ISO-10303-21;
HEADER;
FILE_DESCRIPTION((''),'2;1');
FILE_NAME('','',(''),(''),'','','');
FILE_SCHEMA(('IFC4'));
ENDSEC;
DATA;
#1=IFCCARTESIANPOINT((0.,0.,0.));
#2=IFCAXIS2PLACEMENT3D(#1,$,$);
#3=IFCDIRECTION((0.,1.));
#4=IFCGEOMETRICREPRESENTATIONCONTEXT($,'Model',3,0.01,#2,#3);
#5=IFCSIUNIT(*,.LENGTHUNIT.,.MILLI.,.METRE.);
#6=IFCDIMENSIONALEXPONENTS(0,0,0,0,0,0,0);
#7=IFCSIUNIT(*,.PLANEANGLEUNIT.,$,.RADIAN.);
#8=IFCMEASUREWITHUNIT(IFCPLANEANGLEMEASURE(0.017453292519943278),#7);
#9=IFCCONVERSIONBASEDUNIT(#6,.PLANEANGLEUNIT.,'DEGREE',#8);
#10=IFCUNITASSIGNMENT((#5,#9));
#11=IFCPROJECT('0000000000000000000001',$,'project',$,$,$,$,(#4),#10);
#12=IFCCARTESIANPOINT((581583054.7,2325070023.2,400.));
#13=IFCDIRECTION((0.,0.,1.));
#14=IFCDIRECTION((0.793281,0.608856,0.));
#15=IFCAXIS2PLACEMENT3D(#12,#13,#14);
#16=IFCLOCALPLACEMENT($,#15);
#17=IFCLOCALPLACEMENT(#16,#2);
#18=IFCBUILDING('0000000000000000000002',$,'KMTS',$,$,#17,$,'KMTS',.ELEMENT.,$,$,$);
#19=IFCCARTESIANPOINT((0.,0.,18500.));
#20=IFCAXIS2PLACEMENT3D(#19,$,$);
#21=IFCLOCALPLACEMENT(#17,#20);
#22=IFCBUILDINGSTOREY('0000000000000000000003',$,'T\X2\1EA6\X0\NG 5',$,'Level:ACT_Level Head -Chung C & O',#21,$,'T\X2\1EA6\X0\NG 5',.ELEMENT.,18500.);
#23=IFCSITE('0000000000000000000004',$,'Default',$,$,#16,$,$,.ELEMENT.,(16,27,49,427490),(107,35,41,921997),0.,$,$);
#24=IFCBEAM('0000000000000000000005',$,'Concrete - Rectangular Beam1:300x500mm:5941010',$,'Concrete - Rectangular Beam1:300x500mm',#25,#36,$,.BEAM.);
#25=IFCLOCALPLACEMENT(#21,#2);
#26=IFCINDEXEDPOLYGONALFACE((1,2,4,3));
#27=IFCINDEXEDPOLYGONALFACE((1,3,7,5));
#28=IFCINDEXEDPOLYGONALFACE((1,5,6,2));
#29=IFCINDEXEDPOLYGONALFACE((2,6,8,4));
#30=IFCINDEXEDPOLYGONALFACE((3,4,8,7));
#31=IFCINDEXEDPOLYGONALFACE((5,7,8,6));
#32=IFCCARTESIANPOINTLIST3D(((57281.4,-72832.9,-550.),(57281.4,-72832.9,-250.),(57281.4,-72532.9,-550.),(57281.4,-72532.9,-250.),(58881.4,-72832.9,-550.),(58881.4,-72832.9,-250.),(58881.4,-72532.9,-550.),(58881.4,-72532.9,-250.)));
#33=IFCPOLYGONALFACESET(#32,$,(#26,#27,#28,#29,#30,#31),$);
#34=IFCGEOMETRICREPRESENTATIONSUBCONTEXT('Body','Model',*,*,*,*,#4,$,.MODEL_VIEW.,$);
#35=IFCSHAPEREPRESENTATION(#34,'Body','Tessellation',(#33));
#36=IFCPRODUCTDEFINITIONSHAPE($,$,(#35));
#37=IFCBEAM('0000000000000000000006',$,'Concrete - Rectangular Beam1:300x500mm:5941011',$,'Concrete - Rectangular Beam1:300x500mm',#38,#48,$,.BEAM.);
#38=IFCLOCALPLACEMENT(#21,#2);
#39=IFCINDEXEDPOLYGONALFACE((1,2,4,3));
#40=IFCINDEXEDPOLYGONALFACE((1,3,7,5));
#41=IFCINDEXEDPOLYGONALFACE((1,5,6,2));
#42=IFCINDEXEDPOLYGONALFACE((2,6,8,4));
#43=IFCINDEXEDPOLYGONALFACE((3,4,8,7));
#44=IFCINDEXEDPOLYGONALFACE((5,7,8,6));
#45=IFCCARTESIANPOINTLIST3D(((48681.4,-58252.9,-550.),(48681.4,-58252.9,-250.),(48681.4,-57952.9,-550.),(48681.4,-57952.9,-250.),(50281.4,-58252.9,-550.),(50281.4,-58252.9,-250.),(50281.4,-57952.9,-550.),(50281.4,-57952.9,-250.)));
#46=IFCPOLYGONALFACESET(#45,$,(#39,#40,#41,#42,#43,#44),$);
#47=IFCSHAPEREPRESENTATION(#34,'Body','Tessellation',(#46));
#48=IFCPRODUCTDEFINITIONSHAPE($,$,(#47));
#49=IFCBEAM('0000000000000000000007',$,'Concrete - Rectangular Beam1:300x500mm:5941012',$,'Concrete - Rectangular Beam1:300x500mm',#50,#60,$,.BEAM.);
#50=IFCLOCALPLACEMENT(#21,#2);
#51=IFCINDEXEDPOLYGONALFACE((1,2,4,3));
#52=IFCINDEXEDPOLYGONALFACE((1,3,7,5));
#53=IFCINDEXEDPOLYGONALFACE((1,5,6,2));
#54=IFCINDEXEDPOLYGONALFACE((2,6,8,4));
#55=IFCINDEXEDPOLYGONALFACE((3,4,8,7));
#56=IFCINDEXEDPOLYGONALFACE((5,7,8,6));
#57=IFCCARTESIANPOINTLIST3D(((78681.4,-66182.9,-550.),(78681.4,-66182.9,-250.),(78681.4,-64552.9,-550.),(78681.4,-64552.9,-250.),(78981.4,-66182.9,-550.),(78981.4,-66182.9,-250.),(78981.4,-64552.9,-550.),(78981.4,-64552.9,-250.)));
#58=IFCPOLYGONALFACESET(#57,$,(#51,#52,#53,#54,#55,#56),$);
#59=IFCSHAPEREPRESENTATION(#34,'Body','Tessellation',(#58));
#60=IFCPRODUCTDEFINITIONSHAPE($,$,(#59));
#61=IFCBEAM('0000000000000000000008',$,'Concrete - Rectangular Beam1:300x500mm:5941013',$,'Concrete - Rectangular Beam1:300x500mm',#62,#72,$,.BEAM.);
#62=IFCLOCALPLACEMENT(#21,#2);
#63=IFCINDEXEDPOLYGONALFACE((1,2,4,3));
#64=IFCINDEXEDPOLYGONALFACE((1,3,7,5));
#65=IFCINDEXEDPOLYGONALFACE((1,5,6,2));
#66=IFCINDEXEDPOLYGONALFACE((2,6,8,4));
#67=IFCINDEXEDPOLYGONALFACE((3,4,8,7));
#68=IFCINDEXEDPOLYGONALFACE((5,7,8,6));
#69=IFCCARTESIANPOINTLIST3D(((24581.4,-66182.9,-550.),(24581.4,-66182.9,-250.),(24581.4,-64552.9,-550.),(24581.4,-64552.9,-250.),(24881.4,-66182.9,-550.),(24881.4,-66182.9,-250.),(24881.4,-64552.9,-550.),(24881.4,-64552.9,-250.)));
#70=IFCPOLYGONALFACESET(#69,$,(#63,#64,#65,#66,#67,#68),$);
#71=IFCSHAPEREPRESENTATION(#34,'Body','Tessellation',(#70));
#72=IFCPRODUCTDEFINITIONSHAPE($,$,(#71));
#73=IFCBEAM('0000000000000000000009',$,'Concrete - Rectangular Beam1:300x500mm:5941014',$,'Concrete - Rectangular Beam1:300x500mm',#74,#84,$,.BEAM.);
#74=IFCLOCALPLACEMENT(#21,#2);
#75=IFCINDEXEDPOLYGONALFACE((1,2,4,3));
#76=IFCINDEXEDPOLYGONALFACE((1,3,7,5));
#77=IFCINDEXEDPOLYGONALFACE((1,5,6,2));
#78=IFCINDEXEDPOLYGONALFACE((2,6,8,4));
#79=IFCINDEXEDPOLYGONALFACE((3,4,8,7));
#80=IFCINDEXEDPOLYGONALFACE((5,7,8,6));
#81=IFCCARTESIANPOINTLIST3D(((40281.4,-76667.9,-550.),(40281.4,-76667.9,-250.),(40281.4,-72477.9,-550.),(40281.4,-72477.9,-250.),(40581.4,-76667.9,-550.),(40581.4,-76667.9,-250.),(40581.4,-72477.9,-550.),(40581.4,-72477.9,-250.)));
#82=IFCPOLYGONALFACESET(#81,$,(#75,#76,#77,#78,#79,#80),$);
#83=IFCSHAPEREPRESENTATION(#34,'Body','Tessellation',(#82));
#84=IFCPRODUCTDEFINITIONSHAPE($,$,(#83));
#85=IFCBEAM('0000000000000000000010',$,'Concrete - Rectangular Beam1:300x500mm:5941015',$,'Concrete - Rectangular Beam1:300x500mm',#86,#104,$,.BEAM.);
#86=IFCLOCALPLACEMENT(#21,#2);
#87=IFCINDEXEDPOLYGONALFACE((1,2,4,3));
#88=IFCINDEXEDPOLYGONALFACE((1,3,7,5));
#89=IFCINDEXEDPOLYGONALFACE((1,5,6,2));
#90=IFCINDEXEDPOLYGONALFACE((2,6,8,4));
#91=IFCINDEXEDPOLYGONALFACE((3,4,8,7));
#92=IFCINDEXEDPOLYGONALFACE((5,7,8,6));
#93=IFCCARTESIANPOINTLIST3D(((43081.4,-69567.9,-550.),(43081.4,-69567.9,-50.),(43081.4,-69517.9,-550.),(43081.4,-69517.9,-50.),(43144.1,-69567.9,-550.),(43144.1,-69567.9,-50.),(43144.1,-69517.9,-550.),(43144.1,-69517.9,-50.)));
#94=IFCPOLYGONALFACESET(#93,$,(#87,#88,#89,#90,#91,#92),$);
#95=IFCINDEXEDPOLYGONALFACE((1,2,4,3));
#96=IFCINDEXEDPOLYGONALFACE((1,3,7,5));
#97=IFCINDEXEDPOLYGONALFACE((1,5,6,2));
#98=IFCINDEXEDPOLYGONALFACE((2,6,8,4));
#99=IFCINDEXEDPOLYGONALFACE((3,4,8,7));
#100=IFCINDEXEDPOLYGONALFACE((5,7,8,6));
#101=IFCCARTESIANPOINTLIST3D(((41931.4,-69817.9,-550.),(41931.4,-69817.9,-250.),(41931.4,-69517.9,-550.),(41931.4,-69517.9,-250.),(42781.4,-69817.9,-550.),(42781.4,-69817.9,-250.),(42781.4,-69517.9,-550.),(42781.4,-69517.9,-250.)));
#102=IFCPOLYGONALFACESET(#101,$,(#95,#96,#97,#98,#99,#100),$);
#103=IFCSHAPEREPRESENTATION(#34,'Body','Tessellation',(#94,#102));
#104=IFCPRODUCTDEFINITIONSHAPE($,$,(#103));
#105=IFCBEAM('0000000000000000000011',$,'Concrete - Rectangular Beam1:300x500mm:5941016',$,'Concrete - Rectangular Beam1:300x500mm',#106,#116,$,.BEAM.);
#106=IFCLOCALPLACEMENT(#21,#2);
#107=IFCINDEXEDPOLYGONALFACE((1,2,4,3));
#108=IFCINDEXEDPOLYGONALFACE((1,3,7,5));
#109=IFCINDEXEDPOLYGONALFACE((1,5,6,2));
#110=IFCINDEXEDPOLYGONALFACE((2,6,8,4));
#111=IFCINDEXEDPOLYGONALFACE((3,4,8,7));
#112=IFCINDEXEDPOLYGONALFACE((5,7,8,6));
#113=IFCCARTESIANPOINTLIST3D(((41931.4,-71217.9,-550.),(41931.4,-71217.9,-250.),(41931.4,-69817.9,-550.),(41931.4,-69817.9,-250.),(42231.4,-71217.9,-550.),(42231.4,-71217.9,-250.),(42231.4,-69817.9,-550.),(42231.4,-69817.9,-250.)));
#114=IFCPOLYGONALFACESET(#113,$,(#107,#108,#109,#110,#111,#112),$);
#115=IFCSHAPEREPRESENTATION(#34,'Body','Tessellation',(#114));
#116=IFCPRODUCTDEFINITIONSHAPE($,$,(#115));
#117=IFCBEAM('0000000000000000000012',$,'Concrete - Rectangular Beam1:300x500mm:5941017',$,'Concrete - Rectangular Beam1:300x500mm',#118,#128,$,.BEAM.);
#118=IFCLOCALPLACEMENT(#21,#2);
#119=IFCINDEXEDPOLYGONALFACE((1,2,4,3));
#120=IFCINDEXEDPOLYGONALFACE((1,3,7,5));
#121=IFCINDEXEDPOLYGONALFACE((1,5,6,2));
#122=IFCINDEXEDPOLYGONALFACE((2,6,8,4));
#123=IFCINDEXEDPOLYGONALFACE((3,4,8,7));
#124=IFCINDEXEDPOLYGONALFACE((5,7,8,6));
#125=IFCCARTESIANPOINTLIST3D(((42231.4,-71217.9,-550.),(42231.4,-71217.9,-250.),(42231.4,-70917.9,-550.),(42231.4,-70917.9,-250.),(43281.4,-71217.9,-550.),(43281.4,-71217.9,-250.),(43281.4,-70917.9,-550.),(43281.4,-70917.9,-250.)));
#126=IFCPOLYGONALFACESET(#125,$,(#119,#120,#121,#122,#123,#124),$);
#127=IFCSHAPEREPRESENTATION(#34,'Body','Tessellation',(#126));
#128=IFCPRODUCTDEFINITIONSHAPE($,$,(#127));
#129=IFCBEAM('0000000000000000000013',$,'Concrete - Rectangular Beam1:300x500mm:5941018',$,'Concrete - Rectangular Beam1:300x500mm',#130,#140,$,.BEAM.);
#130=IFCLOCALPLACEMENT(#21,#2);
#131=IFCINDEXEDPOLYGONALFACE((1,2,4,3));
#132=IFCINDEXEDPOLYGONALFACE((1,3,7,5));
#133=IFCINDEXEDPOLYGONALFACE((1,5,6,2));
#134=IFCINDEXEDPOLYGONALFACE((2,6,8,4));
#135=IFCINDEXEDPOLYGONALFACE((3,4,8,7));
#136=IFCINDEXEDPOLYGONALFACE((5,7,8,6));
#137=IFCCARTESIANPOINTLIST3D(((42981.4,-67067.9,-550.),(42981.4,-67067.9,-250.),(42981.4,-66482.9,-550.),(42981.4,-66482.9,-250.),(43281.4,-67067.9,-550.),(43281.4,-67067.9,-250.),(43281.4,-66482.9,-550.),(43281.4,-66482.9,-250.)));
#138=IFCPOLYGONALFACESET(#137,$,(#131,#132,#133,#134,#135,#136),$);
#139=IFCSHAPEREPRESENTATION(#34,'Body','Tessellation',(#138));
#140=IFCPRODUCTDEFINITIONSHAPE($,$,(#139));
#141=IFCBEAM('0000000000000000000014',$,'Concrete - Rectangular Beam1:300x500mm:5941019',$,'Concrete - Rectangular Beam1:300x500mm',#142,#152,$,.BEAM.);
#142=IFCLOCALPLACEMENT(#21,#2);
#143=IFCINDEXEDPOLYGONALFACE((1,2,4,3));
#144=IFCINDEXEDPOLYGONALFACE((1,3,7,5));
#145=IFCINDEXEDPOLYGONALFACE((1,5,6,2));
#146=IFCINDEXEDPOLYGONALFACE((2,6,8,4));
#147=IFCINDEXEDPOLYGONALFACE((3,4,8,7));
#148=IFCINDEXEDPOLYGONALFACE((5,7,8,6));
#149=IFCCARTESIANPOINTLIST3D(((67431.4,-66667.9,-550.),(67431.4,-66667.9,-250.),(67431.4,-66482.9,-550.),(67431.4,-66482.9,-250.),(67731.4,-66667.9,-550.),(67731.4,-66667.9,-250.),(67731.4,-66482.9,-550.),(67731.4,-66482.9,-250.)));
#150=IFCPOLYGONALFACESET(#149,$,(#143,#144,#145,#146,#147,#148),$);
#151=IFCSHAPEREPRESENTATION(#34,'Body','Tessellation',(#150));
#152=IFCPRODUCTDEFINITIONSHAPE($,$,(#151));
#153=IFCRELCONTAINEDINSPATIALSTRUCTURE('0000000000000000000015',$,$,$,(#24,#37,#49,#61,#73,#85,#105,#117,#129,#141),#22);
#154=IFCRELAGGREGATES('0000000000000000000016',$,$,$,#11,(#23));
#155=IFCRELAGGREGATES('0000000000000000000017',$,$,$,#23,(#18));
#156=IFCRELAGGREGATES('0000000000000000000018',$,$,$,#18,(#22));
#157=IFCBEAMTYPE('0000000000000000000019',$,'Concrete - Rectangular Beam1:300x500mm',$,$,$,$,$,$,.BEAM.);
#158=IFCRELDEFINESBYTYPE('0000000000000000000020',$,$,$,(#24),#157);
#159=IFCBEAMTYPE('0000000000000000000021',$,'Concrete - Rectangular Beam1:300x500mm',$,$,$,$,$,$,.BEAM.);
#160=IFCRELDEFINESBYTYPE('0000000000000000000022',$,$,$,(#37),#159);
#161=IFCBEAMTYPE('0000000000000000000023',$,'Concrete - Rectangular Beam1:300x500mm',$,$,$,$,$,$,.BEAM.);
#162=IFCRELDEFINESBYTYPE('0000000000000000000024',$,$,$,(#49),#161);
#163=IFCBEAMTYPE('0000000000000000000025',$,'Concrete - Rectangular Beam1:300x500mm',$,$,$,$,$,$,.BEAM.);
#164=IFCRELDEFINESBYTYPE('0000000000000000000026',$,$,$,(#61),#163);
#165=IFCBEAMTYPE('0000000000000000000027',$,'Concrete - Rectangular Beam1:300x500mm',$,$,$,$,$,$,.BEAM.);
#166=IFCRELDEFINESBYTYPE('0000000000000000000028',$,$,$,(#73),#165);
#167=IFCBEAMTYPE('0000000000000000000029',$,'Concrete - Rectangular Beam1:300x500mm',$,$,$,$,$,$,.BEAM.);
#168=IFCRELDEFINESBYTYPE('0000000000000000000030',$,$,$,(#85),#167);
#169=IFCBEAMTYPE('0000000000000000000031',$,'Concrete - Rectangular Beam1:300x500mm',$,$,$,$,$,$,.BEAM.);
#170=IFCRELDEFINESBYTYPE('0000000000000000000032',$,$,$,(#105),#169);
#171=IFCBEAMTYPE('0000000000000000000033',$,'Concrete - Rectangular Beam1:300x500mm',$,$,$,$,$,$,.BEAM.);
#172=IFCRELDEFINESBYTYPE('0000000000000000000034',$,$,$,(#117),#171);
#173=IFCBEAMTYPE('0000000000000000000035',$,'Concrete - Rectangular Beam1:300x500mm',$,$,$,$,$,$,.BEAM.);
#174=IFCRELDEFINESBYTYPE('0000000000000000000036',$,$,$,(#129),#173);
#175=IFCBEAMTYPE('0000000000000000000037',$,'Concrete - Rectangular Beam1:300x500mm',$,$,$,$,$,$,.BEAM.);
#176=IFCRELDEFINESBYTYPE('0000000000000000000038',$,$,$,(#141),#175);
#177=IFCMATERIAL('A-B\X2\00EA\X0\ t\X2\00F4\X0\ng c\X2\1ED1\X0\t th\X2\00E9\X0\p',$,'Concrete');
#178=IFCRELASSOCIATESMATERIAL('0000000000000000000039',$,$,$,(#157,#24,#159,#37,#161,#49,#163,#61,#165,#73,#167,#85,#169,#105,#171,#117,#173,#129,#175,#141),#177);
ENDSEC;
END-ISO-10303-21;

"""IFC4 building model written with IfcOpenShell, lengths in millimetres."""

from ifc_helpers import new_model, entity, si_unit, converted_unit, direction, frame, origin, place, context, subcontext, project, spatial, indexed_curve, outline, extrude, source, transform, mapped, material, type_object, type_shapes, element, save


model = new_model("IFC4")

# Units and contexts
model_context = context("Model", 3, precision=0.01, world=origin(), true_north=direction((0.0, 1.0)))
body_context = subcontext(model_context, "Body", "Model", "MODEL_VIEW")
ifc_project = project(units=[si_unit("LENGTHUNIT", "METRE", prefix="MILLI"), converted_unit("PLANEANGLEUNIT", "DEGREE", entity("IfcPlaneAngleMeasure", 0.017453292519943278), si_unit("PLANEANGLEUNIT", "RADIAN"), dimensions=[0, 0, 0, 0, 0, 0, 0])], contexts=[model_context])

# Site, building, storey
site_placement = place(None, frame((581583054.7, 2325070023.2, 400.0), z_axis=(0.0, 0.0, 1.0), x_axis=(0.793281, 0.608856, 0.0)))
site = spatial("IfcSite", under=ifc_project, at=site_placement, Name="Default", CompositionType="ELEMENT", RefLatitude=(16, 27, 49, 427490), RefLongitude=(107, 35, 41, 921997), RefElevation=0.0)
building_placement = place(site_placement, origin())
building = spatial("IfcBuilding", under=site, at=building_placement, Name="KMTS", LongName="KMTS", CompositionType="ELEMENT")
storey_placement = place(building_placement, frame((0.0, 0.0, 18500.0)))
storey = spatial("IfcBuildingStorey", under=building, at=storey_placement, Name="TẦNG 5", ObjectType="Level:ACT_Level Head -Chung C & O", LongName="TẦNG 5", CompositionType="ELEMENT", Elevation=18500.0)

# Beams
ifc_material_1 = material(Name="A-Bê tông cốt thép", Category="Concrete")
beam_type_1 = type_object("IfcBeamType", Name="Concrete - Rectangular Beam1:300x500mm", PredefinedType="BEAM", material=ifc_material_1)
shared_shape_1 = source(origin(), body_context, "Body", "SweptSolid", [
    extrude(outline(indexed_curve([(-150.0, -150.0), (150.0, -150.0), (150.0, 150.0), (-150.0, 150.0), (-150.0, -150.0)], self_intersect=False)), frame((57281.4, -72682.9, 18100.0), z_axis=(1.0, 0.0, 0.0), x_axis=(0.0, 0.0, -1.0)), (0.0, 0.0, 1.0), 1600.0),
])
type_shapes(beam_type_1, [shared_shape_1])
beam_1_placement = place(storey_placement, frame((0.0, 0.0, -18500.0)))
element("IfcBeam", 1, at=beam_1_placement, inside=storey, type_object=beam_type_1, material=ifc_material_1, Name="Concrete - Rectangular Beam1:300x500mm:5941010", ObjectType="Concrete - Rectangular Beam1:300x500mm", PredefinedType="BEAM", context=body_context, shape_type="MappedRepresentation", body=[
    mapped(shared_shape_1, transform((0.0, 0.0, 0.0), scale=1.0)),
])
beam_type_2 = type_object("IfcBeamType", Name="Concrete - Rectangular Beam1:300x500mm", PredefinedType="BEAM", material=ifc_material_1)
shared_shape_2 = source(origin(), body_context, "Body", "SweptSolid", [
    extrude(outline(indexed_curve([(-150.0, -150.0), (150.0, -150.0), (150.0, 150.0), (-150.0, 150.0), (-150.0, -150.0)], self_intersect=False)), frame((50281.4, -58102.9, 18100.0), z_axis=(-1.0, 0.0, 0.0), x_axis=(0.0, 0.0, -1.0)), (0.0, 0.0, 1.0), 1600.0),
])
type_shapes(beam_type_2, [shared_shape_2])
beam_2_placement = place(storey_placement, frame((0.0, 0.0, -18500.0)))
element("IfcBeam", 2, at=beam_2_placement, inside=storey, type_object=beam_type_2, material=ifc_material_1, Name="Concrete - Rectangular Beam1:300x500mm:5941011", ObjectType="Concrete - Rectangular Beam1:300x500mm", PredefinedType="BEAM", context=body_context, shape_type="MappedRepresentation", body=[
    mapped(shared_shape_2, transform((0.0, 0.0, 0.0), scale=1.0)),
])
beam_type_3 = type_object("IfcBeamType", Name="Concrete - Rectangular Beam1:300x500mm", PredefinedType="BEAM", material=ifc_material_1)
shared_shape_3 = source(origin(), body_context, "Body", "SweptSolid", [
    extrude(outline(indexed_curve([(-150.0, -150.0), (150.0, -150.0), (150.0, 150.0), (-150.0, 150.0), (-150.0, -150.0)], self_intersect=False)), frame((78831.4, -66182.9, 18100.0), z_axis=(0.0, 1.0, 0.0), x_axis=(-1.0, 0.0, 0.0)), (0.0, 0.0, 1.0), 1630.0),
])
type_shapes(beam_type_3, [shared_shape_3])
beam_3_placement = place(storey_placement, frame((0.0, 0.0, -18500.0)))
element("IfcBeam", 3, at=beam_3_placement, inside=storey, type_object=beam_type_3, material=ifc_material_1, Name="Concrete - Rectangular Beam1:300x500mm:5941012", ObjectType="Concrete - Rectangular Beam1:300x500mm", PredefinedType="BEAM", context=body_context, shape_type="MappedRepresentation", body=[
    mapped(shared_shape_3, transform((0.0, 0.0, 0.0), scale=1.0)),
])
beam_type_4 = type_object("IfcBeamType", Name="Concrete - Rectangular Beam1:300x500mm", PredefinedType="BEAM", material=ifc_material_1)
shared_shape_4 = source(origin(), body_context, "Body", "SweptSolid", [
    extrude(outline(indexed_curve([(-150.0, -150.0), (150.0, -150.0), (150.0, 150.0), (-150.0, 150.0), (-150.0, -150.0)], self_intersect=False)), frame((24731.4, -64552.9, 18100.0), z_axis=(0.0, -1.0, 0.0), x_axis=(-1.0, 0.0, 0.0)), (0.0, 0.0, 1.0), 1630.0),
])
type_shapes(beam_type_4, [shared_shape_4])
beam_4_placement = place(storey_placement, frame((0.0, 0.0, -18500.0)))
element("IfcBeam", 4, at=beam_4_placement, inside=storey, type_object=beam_type_4, material=ifc_material_1, Name="Concrete - Rectangular Beam1:300x500mm:5941013", ObjectType="Concrete - Rectangular Beam1:300x500mm", PredefinedType="BEAM", context=body_context, shape_type="MappedRepresentation", body=[
    mapped(shared_shape_4, transform((0.0, 0.0, 0.0), scale=1.0)),
])
beam_type_5 = type_object("IfcBeamType", Name="Concrete - Rectangular Beam1:300x500mm", PredefinedType="BEAM", material=ifc_material_1)
shared_shape_5 = source(origin(), body_context, "Body", "SweptSolid", [
    extrude(outline(indexed_curve([(-150.0, -150.0), (150.0, -150.0), (150.0, 150.0), (-150.0, 150.0), (-150.0, -150.0)], self_intersect=False)), frame((40431.4, -72477.9, 18100.0), z_axis=(0.0, -1.0, 0.0), x_axis=(-1.0, 0.0, 0.0)), (0.0, 0.0, 1.0), 4190.0),
])
type_shapes(beam_type_5, [shared_shape_5])
beam_5_placement = place(storey_placement, frame((0.0, 0.0, -18500.0)))
element("IfcBeam", 5, at=beam_5_placement, inside=storey, type_object=beam_type_5, material=ifc_material_1, Name="Concrete - Rectangular Beam1:300x500mm:5941014", ObjectType="Concrete - Rectangular Beam1:300x500mm", PredefinedType="BEAM", context=body_context, shape_type="MappedRepresentation", body=[
    mapped(shared_shape_5, transform((0.0, 0.0, 0.0), scale=1.0)),
])
beam_type_6 = type_object("IfcBeamType", Name="Concrete - Rectangular Beam1:300x500mm", PredefinedType="BEAM", material=ifc_material_1)
shared_shape_6 = source(origin(), body_context, "Body", "SweptSolid", [
    extrude(outline(indexed_curve([(-250.0, -25.0), (250.0, -25.0), (250.0, 25.0), (-250.0, 25.0), (-250.0, -25.0)], self_intersect=False)), frame((43144.1, -69542.9, 18200.0), z_axis=(-1.0, 0.0, 0.0), x_axis=(0.0, 0.0, -1.0)), (0.0, 0.0, 1.0), 62.7),
    extrude(outline(indexed_curve([(-150.0, -150.0), (150.0, -150.0), (150.0, 150.0), (-150.0, 150.0), (-150.0, -150.0)], self_intersect=False)), frame((42781.4, -69667.9, 18100.0), z_axis=(-1.0, 0.0, 0.0), x_axis=(0.0, 0.0, -1.0)), (0.0, 0.0, 1.0), 850.0),
])
type_shapes(beam_type_6, [shared_shape_6])
beam_6_placement = place(storey_placement, frame((0.0, 0.0, -18500.0)))
element("IfcBeam", 6, at=beam_6_placement, inside=storey, type_object=beam_type_6, material=ifc_material_1, Name="Concrete - Rectangular Beam1:300x500mm:5941015", ObjectType="Concrete - Rectangular Beam1:300x500mm", PredefinedType="BEAM", context=body_context, shape_type="MappedRepresentation", body=[
    mapped(shared_shape_6, transform((0.0, 0.0, 0.0), scale=1.0)),
])
beam_type_7 = type_object("IfcBeamType", Name="Concrete - Rectangular Beam1:300x500mm", PredefinedType="BEAM", material=ifc_material_1)
shared_shape_7 = source(origin(), body_context, "Body", "SweptSolid", [
    extrude(outline(indexed_curve([(-150.0, -150.0), (150.0, -150.0), (150.0, 150.0), (-150.0, 150.0), (-150.0, -150.0)], self_intersect=False)), frame((42081.4, -69817.9, 18100.0), z_axis=(0.0, -1.0, 0.0), x_axis=(-1.0, 0.0, 0.0)), (0.0, 0.0, 1.0), 1400.0),
])
type_shapes(beam_type_7, [shared_shape_7])
beam_7_placement = place(storey_placement, frame((0.0, 0.0, -18500.0)))
element("IfcBeam", 7, at=beam_7_placement, inside=storey, type_object=beam_type_7, material=ifc_material_1, Name="Concrete - Rectangular Beam1:300x500mm:5941016", ObjectType="Concrete - Rectangular Beam1:300x500mm", PredefinedType="BEAM", context=body_context, shape_type="MappedRepresentation", body=[
    mapped(shared_shape_7, transform((0.0, 0.0, 0.0), scale=1.0)),
])
beam_type_8 = type_object("IfcBeamType", Name="Concrete - Rectangular Beam1:300x500mm", PredefinedType="BEAM", material=ifc_material_1)
shared_shape_8 = source(origin(), body_context, "Body", "SweptSolid", [
    extrude(outline(indexed_curve([(-150.0, -150.0), (150.0, -150.0), (150.0, 150.0), (-150.0, 150.0), (-150.0, -150.0)], self_intersect=False)), frame((42231.4, -71067.9, 18100.0), z_axis=(1.0, 0.0, 0.0), x_axis=(0.0, 0.0, -1.0)), (0.0, 0.0, 1.0), 1050.0),
])
type_shapes(beam_type_8, [shared_shape_8])
beam_8_placement = place(storey_placement, frame((0.0, 0.0, -18500.0)))
element("IfcBeam", 8, at=beam_8_placement, inside=storey, type_object=beam_type_8, material=ifc_material_1, Name="Concrete - Rectangular Beam1:300x500mm:5941017", ObjectType="Concrete - Rectangular Beam1:300x500mm", PredefinedType="BEAM", context=body_context, shape_type="MappedRepresentation", body=[
    mapped(shared_shape_8, transform((0.0, 0.0, 0.0), scale=1.0)),
])
beam_type_9 = type_object("IfcBeamType", Name="Concrete - Rectangular Beam1:300x500mm", PredefinedType="BEAM", material=ifc_material_1)
shared_shape_9 = source(origin(), body_context, "Body", "SweptSolid", [
    extrude(outline(indexed_curve([(-150.0, -150.0), (150.0, -150.0), (150.0, 150.0), (-150.0, 150.0), (-150.0, -150.0)], self_intersect=False)), frame((43131.4, -66482.9, 18100.0), z_axis=(0.0, -1.0, 0.0), x_axis=(-1.0, 0.0, 0.0)), (0.0, 0.0, 1.0), 585.0),
])
type_shapes(beam_type_9, [shared_shape_9])
beam_9_placement = place(storey_placement, frame((0.0, 0.0, -18500.0)))
element("IfcBeam", 9, at=beam_9_placement, inside=storey, type_object=beam_type_9, material=ifc_material_1, Name="Concrete - Rectangular Beam1:300x500mm:5941018", ObjectType="Concrete - Rectangular Beam1:300x500mm", PredefinedType="BEAM", context=body_context, shape_type="MappedRepresentation", body=[
    mapped(shared_shape_9, transform((0.0, 0.0, 0.0), scale=1.0)),
])
beam_type_10 = type_object("IfcBeamType", Name="Concrete - Rectangular Beam1:300x500mm", PredefinedType="BEAM", material=ifc_material_1)
shared_shape_10 = source(origin(), body_context, "Body", "SweptSolid", [
    extrude(outline(indexed_curve([(-150.0, -150.0), (150.0, -150.0), (150.0, 150.0), (-150.0, 150.0), (-150.0, -150.0)], self_intersect=False)), frame((67581.4, -66482.9, 18100.0), z_axis=(0.0, -1.0, 0.0), x_axis=(-1.0, 0.0, 0.0)), (0.0, 0.0, 1.0), 185.0),
])
type_shapes(beam_type_10, [shared_shape_10])
beam_10_placement = place(storey_placement, frame((0.0, 0.0, -18500.0)))
element("IfcBeam", 10, at=beam_10_placement, inside=storey, type_object=beam_type_10, material=ifc_material_1, Name="Concrete - Rectangular Beam1:300x500mm:5941019", ObjectType="Concrete - Rectangular Beam1:300x500mm", PredefinedType="BEAM", context=body_context, shape_type="MappedRepresentation", body=[
    mapped(shared_shape_10, transform((0.0, 0.0, 0.0), scale=1.0)),
])

save(model, "model.ifc")
